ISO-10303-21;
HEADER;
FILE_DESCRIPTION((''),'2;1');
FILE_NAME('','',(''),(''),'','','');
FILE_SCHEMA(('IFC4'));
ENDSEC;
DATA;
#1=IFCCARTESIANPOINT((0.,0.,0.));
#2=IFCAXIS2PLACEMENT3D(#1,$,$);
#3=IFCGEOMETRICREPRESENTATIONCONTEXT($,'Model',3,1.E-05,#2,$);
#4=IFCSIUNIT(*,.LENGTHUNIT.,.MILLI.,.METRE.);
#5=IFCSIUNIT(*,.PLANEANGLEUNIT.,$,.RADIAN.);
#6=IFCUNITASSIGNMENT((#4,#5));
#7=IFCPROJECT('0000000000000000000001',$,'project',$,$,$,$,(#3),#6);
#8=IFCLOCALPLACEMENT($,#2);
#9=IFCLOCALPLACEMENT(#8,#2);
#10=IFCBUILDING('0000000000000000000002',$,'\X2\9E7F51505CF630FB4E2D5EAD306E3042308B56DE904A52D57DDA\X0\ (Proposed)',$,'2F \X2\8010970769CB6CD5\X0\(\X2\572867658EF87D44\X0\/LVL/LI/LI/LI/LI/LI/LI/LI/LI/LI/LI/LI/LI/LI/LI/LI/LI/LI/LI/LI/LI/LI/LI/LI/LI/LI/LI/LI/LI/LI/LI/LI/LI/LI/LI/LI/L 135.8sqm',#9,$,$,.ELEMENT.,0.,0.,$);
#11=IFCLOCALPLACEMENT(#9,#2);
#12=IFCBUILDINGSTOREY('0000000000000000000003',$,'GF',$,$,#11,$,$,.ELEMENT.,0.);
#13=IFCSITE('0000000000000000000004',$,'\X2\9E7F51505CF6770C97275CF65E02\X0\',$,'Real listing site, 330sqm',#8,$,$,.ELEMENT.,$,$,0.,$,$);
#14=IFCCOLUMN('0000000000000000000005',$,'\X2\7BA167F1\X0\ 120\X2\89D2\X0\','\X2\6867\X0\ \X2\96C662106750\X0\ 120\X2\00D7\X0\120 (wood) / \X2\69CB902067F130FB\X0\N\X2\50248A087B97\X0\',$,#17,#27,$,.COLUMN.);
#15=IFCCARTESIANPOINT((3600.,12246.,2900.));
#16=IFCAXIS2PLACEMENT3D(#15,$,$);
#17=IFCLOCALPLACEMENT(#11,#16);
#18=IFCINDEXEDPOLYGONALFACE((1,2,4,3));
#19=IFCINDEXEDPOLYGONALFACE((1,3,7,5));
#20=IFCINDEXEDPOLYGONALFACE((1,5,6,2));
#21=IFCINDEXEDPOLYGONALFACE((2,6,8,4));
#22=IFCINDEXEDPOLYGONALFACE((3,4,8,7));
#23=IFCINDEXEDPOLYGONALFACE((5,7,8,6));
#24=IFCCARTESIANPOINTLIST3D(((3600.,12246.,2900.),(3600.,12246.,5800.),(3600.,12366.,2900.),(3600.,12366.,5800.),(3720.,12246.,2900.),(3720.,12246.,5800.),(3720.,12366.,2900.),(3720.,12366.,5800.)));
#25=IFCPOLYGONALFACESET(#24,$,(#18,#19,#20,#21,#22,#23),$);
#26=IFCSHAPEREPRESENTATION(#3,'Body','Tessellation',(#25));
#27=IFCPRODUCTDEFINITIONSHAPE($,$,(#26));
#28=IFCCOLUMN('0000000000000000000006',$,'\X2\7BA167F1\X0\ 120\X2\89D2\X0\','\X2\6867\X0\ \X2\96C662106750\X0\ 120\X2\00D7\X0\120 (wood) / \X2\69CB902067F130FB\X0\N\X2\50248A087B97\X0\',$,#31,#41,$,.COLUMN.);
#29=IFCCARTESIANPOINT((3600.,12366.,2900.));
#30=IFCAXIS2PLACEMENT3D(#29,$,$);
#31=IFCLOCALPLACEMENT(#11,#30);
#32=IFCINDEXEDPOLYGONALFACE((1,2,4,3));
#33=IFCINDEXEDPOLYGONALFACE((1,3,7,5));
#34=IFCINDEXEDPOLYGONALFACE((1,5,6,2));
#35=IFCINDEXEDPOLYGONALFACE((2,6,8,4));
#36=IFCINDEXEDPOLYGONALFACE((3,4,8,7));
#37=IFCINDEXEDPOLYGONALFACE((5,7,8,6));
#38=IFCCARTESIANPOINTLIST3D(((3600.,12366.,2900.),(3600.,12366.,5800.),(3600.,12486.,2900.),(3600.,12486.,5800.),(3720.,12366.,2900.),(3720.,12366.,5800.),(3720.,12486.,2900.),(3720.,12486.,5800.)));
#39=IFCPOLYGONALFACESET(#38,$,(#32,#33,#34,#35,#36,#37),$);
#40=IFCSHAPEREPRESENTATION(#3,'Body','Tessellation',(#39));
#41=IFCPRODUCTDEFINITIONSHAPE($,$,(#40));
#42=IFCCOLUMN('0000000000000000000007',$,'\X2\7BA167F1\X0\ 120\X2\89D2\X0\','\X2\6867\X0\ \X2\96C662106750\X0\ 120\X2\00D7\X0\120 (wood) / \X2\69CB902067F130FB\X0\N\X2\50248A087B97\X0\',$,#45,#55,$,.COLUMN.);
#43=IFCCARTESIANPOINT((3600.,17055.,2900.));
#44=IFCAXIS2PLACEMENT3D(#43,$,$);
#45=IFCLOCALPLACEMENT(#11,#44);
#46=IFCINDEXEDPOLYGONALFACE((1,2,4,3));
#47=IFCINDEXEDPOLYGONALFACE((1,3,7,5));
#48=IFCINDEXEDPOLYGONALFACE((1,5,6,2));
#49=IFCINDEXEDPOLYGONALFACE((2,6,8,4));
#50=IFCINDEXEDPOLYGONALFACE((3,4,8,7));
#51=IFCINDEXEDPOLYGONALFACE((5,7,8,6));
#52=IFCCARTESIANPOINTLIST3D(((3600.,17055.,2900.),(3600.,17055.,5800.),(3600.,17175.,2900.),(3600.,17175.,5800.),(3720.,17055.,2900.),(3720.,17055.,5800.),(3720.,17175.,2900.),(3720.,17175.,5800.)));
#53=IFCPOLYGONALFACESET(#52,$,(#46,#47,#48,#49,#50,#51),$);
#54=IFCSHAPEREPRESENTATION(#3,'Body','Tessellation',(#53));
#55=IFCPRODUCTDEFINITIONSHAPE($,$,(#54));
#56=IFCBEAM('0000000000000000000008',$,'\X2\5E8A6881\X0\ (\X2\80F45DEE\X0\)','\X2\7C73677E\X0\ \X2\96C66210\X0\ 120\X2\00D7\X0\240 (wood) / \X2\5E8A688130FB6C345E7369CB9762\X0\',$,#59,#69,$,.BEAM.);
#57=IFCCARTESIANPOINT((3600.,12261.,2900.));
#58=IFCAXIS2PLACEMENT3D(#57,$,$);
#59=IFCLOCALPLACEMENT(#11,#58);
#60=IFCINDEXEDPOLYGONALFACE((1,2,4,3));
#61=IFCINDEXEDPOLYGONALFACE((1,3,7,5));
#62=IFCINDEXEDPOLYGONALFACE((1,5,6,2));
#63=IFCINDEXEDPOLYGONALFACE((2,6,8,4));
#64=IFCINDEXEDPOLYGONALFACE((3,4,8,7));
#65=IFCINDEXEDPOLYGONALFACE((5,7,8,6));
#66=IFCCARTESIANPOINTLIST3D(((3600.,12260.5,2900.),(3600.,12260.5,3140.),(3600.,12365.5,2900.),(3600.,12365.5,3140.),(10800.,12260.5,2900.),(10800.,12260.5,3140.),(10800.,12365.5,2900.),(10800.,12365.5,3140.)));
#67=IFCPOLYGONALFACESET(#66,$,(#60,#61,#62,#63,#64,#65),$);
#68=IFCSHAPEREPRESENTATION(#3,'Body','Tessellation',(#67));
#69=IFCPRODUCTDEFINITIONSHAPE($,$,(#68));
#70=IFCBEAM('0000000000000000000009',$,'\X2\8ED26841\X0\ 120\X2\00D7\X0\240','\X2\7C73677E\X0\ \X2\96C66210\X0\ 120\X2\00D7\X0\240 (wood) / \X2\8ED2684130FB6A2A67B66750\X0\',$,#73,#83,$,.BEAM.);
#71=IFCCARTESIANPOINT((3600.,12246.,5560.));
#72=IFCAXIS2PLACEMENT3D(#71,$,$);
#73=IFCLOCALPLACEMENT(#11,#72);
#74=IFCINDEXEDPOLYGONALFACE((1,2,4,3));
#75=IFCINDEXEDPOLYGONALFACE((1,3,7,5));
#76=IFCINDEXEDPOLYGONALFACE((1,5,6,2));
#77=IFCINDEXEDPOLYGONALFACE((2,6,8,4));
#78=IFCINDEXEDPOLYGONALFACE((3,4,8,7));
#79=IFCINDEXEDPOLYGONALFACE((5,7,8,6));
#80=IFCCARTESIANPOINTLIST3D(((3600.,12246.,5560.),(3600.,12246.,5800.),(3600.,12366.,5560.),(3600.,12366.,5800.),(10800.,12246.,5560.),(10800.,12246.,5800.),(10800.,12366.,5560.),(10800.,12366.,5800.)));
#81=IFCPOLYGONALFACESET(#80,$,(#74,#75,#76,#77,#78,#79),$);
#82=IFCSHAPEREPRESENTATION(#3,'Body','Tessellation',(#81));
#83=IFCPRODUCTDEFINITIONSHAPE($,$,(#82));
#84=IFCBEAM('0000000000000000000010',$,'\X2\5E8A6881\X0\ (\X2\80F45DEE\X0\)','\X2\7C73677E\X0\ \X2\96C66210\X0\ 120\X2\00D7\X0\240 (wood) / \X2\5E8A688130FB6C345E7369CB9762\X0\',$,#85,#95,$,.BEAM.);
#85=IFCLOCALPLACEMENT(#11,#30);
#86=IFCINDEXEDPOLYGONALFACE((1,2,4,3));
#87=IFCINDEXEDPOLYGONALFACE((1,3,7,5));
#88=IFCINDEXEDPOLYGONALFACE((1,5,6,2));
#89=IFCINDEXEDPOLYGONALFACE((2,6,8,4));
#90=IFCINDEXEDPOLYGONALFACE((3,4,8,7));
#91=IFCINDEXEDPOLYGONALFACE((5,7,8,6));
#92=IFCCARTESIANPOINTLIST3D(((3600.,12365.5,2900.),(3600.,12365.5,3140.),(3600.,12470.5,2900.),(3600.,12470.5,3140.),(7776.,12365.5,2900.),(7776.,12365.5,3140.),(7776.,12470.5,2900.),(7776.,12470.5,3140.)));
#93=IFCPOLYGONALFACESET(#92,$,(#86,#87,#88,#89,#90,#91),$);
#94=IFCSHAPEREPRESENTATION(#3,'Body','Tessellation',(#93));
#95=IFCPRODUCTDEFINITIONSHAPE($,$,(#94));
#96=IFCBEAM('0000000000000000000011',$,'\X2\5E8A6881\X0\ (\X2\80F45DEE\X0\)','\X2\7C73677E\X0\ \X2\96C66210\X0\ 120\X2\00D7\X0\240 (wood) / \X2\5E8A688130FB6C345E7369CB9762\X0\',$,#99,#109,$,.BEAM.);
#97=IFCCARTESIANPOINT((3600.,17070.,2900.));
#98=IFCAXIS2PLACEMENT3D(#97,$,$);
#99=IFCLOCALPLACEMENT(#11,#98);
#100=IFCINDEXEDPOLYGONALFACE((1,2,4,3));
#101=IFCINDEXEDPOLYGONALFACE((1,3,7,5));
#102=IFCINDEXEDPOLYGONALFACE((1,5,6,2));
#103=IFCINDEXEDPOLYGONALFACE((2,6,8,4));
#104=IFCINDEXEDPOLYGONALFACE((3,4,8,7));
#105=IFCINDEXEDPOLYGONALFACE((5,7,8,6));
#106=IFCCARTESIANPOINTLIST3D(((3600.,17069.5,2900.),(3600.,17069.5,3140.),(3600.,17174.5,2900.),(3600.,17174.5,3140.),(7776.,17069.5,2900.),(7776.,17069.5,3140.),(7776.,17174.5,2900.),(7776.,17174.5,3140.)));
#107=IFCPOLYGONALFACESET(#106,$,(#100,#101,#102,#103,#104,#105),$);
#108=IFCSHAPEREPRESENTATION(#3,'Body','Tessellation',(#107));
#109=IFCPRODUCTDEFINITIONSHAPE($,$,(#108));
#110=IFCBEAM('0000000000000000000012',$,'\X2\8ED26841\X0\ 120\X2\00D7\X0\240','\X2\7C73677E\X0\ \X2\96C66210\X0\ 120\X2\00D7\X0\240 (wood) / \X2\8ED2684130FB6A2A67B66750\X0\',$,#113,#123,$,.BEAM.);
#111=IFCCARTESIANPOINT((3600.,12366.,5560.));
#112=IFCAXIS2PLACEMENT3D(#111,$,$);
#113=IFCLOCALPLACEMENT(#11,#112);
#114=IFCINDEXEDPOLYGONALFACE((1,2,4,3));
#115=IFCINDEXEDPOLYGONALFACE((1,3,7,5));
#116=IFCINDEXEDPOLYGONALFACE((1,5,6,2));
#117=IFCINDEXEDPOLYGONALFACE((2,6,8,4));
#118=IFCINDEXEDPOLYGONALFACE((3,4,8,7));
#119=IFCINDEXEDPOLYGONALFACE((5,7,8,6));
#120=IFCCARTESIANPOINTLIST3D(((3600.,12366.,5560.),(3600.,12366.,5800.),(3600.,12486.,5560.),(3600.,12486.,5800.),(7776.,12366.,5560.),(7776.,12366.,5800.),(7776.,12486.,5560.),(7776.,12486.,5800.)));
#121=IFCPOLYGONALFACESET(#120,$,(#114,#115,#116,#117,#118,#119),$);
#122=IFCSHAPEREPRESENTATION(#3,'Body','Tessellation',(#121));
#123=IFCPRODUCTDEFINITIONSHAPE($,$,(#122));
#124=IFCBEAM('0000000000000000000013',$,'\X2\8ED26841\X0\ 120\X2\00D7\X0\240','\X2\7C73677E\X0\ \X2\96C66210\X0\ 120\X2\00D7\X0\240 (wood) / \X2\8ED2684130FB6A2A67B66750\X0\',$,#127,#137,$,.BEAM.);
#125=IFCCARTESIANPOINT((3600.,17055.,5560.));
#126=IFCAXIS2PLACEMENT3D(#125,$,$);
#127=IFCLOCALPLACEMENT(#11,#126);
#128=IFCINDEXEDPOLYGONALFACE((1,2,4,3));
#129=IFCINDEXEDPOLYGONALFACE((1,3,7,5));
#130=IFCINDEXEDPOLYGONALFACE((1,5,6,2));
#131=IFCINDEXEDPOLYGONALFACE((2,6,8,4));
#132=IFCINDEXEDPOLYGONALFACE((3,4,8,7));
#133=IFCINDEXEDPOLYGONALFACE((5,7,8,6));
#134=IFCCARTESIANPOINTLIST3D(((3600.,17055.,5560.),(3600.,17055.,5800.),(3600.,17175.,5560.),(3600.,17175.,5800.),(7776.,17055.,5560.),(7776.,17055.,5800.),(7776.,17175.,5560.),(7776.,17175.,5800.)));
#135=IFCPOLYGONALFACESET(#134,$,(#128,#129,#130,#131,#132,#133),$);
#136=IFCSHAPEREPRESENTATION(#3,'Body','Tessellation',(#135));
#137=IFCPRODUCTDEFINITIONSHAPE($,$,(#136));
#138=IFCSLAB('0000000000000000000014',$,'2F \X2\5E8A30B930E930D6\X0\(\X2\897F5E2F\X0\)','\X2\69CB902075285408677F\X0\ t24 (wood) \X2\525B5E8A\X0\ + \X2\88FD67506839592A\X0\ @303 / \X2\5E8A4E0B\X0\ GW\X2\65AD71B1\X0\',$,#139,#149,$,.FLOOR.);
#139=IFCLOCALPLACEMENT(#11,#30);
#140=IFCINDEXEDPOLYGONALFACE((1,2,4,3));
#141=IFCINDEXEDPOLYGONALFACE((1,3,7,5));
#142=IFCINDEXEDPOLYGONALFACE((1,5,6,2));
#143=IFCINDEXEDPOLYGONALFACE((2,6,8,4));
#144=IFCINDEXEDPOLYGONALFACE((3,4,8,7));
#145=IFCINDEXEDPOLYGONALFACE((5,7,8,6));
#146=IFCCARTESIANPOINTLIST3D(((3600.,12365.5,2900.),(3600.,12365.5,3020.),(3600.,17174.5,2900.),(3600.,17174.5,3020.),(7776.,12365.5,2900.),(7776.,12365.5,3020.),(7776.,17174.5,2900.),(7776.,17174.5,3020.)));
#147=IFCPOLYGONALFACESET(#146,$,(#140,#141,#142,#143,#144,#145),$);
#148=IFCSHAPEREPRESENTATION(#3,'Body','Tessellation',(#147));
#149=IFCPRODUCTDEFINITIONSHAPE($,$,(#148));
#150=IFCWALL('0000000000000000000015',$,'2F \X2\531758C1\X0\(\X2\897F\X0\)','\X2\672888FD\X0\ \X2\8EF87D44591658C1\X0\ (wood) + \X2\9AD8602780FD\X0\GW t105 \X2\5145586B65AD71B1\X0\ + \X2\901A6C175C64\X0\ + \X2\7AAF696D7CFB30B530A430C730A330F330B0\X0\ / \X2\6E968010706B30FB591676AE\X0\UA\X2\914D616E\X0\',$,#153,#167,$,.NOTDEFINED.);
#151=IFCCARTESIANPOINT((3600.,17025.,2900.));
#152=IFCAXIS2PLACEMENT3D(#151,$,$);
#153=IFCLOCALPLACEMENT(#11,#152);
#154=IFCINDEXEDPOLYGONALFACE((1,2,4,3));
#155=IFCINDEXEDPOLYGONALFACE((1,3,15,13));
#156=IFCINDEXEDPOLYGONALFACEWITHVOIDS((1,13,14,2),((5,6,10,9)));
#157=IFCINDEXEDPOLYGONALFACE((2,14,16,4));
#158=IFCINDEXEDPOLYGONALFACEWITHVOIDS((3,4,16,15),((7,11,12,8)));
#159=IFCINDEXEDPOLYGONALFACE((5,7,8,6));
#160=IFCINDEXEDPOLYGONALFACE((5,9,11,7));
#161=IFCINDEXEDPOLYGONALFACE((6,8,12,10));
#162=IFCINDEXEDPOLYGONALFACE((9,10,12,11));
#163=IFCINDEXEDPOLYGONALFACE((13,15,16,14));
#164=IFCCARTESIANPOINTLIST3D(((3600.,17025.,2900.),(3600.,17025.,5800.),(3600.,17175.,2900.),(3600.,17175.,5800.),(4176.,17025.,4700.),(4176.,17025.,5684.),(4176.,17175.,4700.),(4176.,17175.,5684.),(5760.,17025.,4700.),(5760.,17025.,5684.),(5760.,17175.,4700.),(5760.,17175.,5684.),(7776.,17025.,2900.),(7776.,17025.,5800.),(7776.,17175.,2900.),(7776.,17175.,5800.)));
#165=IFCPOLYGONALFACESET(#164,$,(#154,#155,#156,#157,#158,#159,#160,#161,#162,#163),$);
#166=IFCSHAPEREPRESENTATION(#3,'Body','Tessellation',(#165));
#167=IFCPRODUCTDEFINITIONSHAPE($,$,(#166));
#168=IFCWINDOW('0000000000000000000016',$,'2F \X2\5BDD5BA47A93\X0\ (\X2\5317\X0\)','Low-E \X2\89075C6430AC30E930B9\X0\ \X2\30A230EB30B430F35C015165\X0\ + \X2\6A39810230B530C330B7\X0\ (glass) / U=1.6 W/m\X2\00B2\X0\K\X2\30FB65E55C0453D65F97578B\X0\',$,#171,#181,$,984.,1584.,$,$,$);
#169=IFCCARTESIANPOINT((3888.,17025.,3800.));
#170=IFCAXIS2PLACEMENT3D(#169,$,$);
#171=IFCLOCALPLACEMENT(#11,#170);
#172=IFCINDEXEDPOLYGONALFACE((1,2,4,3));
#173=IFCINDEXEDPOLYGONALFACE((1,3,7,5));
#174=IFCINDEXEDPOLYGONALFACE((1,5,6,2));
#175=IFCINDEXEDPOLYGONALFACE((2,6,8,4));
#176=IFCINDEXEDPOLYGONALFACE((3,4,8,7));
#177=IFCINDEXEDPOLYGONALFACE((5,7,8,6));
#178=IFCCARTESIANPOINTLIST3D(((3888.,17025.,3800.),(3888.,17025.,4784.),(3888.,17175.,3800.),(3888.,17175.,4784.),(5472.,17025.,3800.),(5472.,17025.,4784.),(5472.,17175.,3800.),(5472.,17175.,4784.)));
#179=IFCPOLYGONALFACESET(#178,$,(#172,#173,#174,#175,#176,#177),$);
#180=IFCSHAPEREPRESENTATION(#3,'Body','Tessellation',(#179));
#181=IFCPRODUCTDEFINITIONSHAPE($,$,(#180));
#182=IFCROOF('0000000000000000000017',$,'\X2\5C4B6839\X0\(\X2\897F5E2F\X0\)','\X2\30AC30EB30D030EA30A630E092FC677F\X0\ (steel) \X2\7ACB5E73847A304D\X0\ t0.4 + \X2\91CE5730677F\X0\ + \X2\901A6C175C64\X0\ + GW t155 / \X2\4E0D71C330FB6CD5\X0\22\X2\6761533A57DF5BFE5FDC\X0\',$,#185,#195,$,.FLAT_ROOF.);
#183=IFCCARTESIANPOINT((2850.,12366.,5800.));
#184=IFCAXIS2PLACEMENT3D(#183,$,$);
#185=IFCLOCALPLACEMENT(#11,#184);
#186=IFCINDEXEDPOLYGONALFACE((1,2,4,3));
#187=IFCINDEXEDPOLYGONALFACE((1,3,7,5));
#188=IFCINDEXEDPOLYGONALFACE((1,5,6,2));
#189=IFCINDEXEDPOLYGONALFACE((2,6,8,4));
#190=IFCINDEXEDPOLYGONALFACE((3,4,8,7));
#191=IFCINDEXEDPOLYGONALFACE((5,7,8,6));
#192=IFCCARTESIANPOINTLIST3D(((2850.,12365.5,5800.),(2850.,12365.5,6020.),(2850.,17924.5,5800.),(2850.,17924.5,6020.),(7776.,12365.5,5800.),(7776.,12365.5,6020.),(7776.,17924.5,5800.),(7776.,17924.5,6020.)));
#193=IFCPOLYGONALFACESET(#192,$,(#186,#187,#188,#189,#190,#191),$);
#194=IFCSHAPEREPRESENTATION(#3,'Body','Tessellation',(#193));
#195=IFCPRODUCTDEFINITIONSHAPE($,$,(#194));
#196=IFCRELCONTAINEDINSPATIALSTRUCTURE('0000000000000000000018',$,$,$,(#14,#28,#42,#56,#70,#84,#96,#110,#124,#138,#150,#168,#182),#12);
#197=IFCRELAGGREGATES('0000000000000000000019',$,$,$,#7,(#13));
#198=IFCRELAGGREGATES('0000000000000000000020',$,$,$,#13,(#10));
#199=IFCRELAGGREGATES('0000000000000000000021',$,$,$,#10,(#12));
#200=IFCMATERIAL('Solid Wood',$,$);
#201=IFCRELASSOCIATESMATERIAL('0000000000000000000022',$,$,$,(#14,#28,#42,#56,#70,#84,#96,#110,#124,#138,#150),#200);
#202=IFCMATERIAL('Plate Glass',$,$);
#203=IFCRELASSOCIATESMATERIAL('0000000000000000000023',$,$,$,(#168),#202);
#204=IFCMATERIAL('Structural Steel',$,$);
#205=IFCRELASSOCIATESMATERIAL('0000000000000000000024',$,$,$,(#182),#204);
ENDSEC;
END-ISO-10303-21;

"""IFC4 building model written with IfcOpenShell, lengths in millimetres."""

from ifc_helpers import new_model, si_unit, frame, frame_2d, origin, place, context, project, spatial, rectangle, extrude, material, element, fill, save


model = new_model("IFC4")

# Units and contexts
model_context = context("Model", 3, precision=1e-05, world=origin())
ifc_project = project(units=[si_unit("LENGTHUNIT", "METRE", prefix="MILLI"), si_unit("PLANEANGLEUNIT", "RADIAN")], contexts=[model_context])

# Site, building, storey
site_placement = place(None, origin())
site = spatial("IfcSite", under=ifc_project, at=site_placement, Name="鹿児島県霧島市", ObjectType="Real listing site, 330sqm", CompositionType="ELEMENT", RefElevation=0.0)
building_placement = place(site_placement, origin())
building = spatial("IfcBuilding", under=site, at=building_placement, Name="鹿児島・中庭のある回遊動線 (Proposed)", ObjectType="2F 耐震構法(在来軸組/LVL/LI/LI/LI/LI/LI/LI/LI/LI/LI/LI/LI/LI/LI/LI/LI/LI/LI/LI/LI/LI/LI/LI/LI/LI/LI/LI/LI/LI/LI/LI/LI/LI/LI/LI/LI/L 135.8sqm", CompositionType="ELEMENT", ElevationOfRefHeight=0.0, ElevationOfTerrain=0.0)
storey_placement = place(building_placement, origin())
storey = spatial("IfcBuildingStorey", under=building, at=storey_placement, Name="GF", CompositionType="ELEMENT", Elevation=0.0)

# Columns
ifc_material_1 = material(Name="Solid Wood")
column_1_placement = place(storey_placement, frame((3600.0, 12246.0, 2900.0)))
element("IfcColumn", 1, at=column_1_placement, inside=storey, material=ifc_material_1, Name="管柱 120角", Description="桧 集成材 120×120 (wood) / 構造柱・N値計算", PredefinedType="COLUMN", context=model_context, shape_type="SweptSolid", body=[
    extrude(rectangle(XDim=120.0, YDim=120.0, at=frame_2d((60.0, 60.0))), frame((3600.0, 12246.0, 2900.0)), (0.0, 0.0, 1.0), 2900.0),
])
column_2_placement = place(storey_placement, frame((3600.0, 12366.0, 2900.0)))
element("IfcColumn", 2, at=column_2_placement, inside=storey, material=ifc_material_1, Name="管柱 120角", Description="桧 集成材 120×120 (wood) / 構造柱・N値計算", PredefinedType="COLUMN", context=model_context, shape_type="SweptSolid", body=[
    extrude(rectangle(XDim=120.0, YDim=120.0, at=frame_2d((60.0, 60.0))), frame((3600.0, 12366.0, 2900.0)), (0.0, 0.0, 1.0), 2900.0),
])
column_3_placement = place(storey_placement, frame((3600.0, 17055.0, 2900.0)))
element("IfcColumn", 3, at=column_3_placement, inside=storey, material=ifc_material_1, Name="管柱 120角", Description="桧 集成材 120×120 (wood) / 構造柱・N値計算", PredefinedType="COLUMN", context=model_context, shape_type="SweptSolid", body=[
    extrude(rectangle(XDim=120.0, YDim=120.0, at=frame_2d((60.0, 60.0))), frame((3600.0, 17055.0, 2900.0)), (0.0, 0.0, 1.0), 2900.0),
])

# Beams
beam_1_placement = place(storey_placement, frame((3600.0, 12261.0, 2900.0)))
element("IfcBeam", 4, at=beam_1_placement, inside=storey, material=ifc_material_1, Name="床梁 (胴差)", Description="米松 集成 120×240 (wood) / 床梁・水平構面", PredefinedType="BEAM", context=model_context, shape_type="SweptSolid", body=[
    extrude(rectangle(XDim=7200.0, YDim=105.0, at=frame_2d((3600.0, 52.0))), frame((3600.0, 12261.0, 2900.0)), (0.0, 0.0, 1.0), 240.0),
])
beam_2_placement = place(storey_placement, frame((3600.0, 12246.0, 5560.0)))
element("IfcBeam", 5, at=beam_2_placement, inside=storey, material=ifc_material_1, Name="軒桁 120×240", Description="米松 集成 120×240 (wood) / 軒桁・横架材", PredefinedType="BEAM", context=model_context, shape_type="SweptSolid", body=[
    extrude(rectangle(XDim=7200.0, YDim=120.0, at=frame_2d((3600.0, 60.0))), frame((3600.0, 12246.0, 5560.0)), (0.0, 0.0, 1.0), 240.0),
])
beam_3_placement = place(storey_placement, frame((3600.0, 12366.0, 2900.0)))
element("IfcBeam", 6, at=beam_3_placement, inside=storey, material=ifc_material_1, Name="床梁 (胴差)", Description="米松 集成 120×240 (wood) / 床梁・水平構面", PredefinedType="BEAM", context=model_context, shape_type="SweptSolid", body=[
    extrude(rectangle(XDim=4176.0, YDim=105.0, at=frame_2d((2088.0, 52.0))), frame((3600.0, 12366.0, 2900.0)), (0.0, 0.0, 1.0), 240.0),
])
beam_4_placement = place(storey_placement, frame((3600.0, 17070.0, 2900.0)))
element("IfcBeam", 7, at=beam_4_placement, inside=storey, material=ifc_material_1, Name="床梁 (胴差)", Description="米松 集成 120×240 (wood) / 床梁・水平構面", PredefinedType="BEAM", context=model_context, shape_type="SweptSolid", body=[
    extrude(rectangle(XDim=4176.0, YDim=105.0, at=frame_2d((2088.0, 52.0))), frame((3600.0, 17070.0, 2900.0)), (0.0, 0.0, 1.0), 240.0),
])
beam_5_placement = place(storey_placement, frame((3600.0, 12366.0, 5560.0)))
element("IfcBeam", 8, at=beam_5_placement, inside=storey, material=ifc_material_1, Name="軒桁 120×240", Description="米松 集成 120×240 (wood) / 軒桁・横架材", PredefinedType="BEAM", context=model_context, shape_type="SweptSolid", body=[
    extrude(rectangle(XDim=4176.0, YDim=120.0, at=frame_2d((2088.0, 60.0))), frame((3600.0, 12366.0, 5560.0)), (0.0, 0.0, 1.0), 240.0),
])
beam_6_placement = place(storey_placement, frame((3600.0, 17055.0, 5560.0)))
element("IfcBeam", 9, at=beam_6_placement, inside=storey, material=ifc_material_1, Name="軒桁 120×240", Description="米松 集成 120×240 (wood) / 軒桁・横架材", PredefinedType="BEAM", context=model_context, shape_type="SweptSolid", body=[
    extrude(rectangle(XDim=4176.0, YDim=120.0, at=frame_2d((2088.0, 60.0))), frame((3600.0, 17055.0, 5560.0)), (0.0, 0.0, 1.0), 240.0),
])

# Slab
slab_placement = place(storey_placement, frame((3600.0, 12366.0, 2900.0)))
element("IfcSlab", 10, at=slab_placement, inside=storey, material=ifc_material_1, Name="2F 床スラブ(西帯)", Description="構造用合板 t24 (wood) 剛床 + 製材根太 @303 / 床下 GW断熱", PredefinedType="FLOOR", context=model_context, shape_type="SweptSolid", body=[
    extrude(rectangle(XDim=4176.0, YDim=4809.0, at=frame_2d((2088.0, 2404.0))), frame((3600.0, 12366.0, 2900.0)), (0.0, 0.0, 1.0), 120.0),
])

# Wall, opening, window
wall_1_placement = place(storey_placement, frame((3600.0, 17025.0, 2900.0)))
wall_1 = element("IfcWall", 11, at=wall_1_placement, inside=storey, material=ifc_material_1, Name="2F 北壁(西)", Description="木製 軸組外壁 (wood) + 高性能GW t105 充填断熱 + 通気層 + 窯業系サイディング / 準耐火・外皮UA配慮", PredefinedType="NOTDEFINED", context=model_context, shape_type="SweptSolid", body=[
    extrude(rectangle(XDim=4176.0, YDim=150.0, at=frame_2d((2088.0, 75.0))), frame((3600.0, 17025.0, 2900.0)), (0.0, 0.0, 1.0), 2900.0),
])
opening_placement = place(storey_placement, frame((3888.0, 17025.0, 3800.0)))
opening = element("IfcOpeningElement", 12, at=opening_placement, cuts=wall_1, PredefinedType="NOTDEFINED", context=model_context, shape_type="SweptSolid", body=[
    extrude(rectangle(XDim=1584.0, YDim=150.0, at=frame_2d((792.0, 75.0))), frame((3888.0, 17025.0, 3800.0)), (0.0, 0.0, 1.0), 984.0),
])
ifc_material_2 = material(Name="Plate Glass")
window_placement = place(storey_placement, frame((3888.0, 17025.0, 3800.0)))
window = element("IfcWindow", 13, at=window_placement, inside=storey, material=ifc_material_2, Name="2F 寝室窓 (北)", Description="Low-E 複層ガラス アルゴン封入 + 樹脂サッシ (glass) / U=1.6 W/m²K・日射取得型", OverallHeight=984.0, OverallWidth=1584.0, context=model_context, shape_type="SweptSolid", body=[
    extrude(rectangle(XDim=1584.0, YDim=150.0, at=frame_2d((792.0, 75.0))), frame((3888.0, 17025.0, 3800.0)), (0.0, 0.0, 1.0), 984.0),
])
fill(opening, window)

# Roof
ifc_material_3 = material(Name="Structural Steel")
for number, where, name in (
    (14, (2850.0, 12366.0, 5800.0), "屋根(西帯)"),
):
    element("IfcRoof", number, at=place(storey_placement, frame(where)), inside=storey, material=ifc_material_3, Name=name, Description="ガルバリウム鋼板 (steel) 立平葺き t0.4 + 野地板 + 通気層 + GW t155 / 不燃・法22条区域対応", PredefinedType="FLAT_ROOF", context=model_context, shape_type="SweptSolid", body=[
        extrude(rectangle(XDim=4926.0, YDim=5559.0, at=frame_2d((2463.0, 2779.0))), frame((2850.0, 12366.0, 5800.0)), (0.0, 0.0, 1.0), 220.0),
    ])

save(model, "model.ifc")
